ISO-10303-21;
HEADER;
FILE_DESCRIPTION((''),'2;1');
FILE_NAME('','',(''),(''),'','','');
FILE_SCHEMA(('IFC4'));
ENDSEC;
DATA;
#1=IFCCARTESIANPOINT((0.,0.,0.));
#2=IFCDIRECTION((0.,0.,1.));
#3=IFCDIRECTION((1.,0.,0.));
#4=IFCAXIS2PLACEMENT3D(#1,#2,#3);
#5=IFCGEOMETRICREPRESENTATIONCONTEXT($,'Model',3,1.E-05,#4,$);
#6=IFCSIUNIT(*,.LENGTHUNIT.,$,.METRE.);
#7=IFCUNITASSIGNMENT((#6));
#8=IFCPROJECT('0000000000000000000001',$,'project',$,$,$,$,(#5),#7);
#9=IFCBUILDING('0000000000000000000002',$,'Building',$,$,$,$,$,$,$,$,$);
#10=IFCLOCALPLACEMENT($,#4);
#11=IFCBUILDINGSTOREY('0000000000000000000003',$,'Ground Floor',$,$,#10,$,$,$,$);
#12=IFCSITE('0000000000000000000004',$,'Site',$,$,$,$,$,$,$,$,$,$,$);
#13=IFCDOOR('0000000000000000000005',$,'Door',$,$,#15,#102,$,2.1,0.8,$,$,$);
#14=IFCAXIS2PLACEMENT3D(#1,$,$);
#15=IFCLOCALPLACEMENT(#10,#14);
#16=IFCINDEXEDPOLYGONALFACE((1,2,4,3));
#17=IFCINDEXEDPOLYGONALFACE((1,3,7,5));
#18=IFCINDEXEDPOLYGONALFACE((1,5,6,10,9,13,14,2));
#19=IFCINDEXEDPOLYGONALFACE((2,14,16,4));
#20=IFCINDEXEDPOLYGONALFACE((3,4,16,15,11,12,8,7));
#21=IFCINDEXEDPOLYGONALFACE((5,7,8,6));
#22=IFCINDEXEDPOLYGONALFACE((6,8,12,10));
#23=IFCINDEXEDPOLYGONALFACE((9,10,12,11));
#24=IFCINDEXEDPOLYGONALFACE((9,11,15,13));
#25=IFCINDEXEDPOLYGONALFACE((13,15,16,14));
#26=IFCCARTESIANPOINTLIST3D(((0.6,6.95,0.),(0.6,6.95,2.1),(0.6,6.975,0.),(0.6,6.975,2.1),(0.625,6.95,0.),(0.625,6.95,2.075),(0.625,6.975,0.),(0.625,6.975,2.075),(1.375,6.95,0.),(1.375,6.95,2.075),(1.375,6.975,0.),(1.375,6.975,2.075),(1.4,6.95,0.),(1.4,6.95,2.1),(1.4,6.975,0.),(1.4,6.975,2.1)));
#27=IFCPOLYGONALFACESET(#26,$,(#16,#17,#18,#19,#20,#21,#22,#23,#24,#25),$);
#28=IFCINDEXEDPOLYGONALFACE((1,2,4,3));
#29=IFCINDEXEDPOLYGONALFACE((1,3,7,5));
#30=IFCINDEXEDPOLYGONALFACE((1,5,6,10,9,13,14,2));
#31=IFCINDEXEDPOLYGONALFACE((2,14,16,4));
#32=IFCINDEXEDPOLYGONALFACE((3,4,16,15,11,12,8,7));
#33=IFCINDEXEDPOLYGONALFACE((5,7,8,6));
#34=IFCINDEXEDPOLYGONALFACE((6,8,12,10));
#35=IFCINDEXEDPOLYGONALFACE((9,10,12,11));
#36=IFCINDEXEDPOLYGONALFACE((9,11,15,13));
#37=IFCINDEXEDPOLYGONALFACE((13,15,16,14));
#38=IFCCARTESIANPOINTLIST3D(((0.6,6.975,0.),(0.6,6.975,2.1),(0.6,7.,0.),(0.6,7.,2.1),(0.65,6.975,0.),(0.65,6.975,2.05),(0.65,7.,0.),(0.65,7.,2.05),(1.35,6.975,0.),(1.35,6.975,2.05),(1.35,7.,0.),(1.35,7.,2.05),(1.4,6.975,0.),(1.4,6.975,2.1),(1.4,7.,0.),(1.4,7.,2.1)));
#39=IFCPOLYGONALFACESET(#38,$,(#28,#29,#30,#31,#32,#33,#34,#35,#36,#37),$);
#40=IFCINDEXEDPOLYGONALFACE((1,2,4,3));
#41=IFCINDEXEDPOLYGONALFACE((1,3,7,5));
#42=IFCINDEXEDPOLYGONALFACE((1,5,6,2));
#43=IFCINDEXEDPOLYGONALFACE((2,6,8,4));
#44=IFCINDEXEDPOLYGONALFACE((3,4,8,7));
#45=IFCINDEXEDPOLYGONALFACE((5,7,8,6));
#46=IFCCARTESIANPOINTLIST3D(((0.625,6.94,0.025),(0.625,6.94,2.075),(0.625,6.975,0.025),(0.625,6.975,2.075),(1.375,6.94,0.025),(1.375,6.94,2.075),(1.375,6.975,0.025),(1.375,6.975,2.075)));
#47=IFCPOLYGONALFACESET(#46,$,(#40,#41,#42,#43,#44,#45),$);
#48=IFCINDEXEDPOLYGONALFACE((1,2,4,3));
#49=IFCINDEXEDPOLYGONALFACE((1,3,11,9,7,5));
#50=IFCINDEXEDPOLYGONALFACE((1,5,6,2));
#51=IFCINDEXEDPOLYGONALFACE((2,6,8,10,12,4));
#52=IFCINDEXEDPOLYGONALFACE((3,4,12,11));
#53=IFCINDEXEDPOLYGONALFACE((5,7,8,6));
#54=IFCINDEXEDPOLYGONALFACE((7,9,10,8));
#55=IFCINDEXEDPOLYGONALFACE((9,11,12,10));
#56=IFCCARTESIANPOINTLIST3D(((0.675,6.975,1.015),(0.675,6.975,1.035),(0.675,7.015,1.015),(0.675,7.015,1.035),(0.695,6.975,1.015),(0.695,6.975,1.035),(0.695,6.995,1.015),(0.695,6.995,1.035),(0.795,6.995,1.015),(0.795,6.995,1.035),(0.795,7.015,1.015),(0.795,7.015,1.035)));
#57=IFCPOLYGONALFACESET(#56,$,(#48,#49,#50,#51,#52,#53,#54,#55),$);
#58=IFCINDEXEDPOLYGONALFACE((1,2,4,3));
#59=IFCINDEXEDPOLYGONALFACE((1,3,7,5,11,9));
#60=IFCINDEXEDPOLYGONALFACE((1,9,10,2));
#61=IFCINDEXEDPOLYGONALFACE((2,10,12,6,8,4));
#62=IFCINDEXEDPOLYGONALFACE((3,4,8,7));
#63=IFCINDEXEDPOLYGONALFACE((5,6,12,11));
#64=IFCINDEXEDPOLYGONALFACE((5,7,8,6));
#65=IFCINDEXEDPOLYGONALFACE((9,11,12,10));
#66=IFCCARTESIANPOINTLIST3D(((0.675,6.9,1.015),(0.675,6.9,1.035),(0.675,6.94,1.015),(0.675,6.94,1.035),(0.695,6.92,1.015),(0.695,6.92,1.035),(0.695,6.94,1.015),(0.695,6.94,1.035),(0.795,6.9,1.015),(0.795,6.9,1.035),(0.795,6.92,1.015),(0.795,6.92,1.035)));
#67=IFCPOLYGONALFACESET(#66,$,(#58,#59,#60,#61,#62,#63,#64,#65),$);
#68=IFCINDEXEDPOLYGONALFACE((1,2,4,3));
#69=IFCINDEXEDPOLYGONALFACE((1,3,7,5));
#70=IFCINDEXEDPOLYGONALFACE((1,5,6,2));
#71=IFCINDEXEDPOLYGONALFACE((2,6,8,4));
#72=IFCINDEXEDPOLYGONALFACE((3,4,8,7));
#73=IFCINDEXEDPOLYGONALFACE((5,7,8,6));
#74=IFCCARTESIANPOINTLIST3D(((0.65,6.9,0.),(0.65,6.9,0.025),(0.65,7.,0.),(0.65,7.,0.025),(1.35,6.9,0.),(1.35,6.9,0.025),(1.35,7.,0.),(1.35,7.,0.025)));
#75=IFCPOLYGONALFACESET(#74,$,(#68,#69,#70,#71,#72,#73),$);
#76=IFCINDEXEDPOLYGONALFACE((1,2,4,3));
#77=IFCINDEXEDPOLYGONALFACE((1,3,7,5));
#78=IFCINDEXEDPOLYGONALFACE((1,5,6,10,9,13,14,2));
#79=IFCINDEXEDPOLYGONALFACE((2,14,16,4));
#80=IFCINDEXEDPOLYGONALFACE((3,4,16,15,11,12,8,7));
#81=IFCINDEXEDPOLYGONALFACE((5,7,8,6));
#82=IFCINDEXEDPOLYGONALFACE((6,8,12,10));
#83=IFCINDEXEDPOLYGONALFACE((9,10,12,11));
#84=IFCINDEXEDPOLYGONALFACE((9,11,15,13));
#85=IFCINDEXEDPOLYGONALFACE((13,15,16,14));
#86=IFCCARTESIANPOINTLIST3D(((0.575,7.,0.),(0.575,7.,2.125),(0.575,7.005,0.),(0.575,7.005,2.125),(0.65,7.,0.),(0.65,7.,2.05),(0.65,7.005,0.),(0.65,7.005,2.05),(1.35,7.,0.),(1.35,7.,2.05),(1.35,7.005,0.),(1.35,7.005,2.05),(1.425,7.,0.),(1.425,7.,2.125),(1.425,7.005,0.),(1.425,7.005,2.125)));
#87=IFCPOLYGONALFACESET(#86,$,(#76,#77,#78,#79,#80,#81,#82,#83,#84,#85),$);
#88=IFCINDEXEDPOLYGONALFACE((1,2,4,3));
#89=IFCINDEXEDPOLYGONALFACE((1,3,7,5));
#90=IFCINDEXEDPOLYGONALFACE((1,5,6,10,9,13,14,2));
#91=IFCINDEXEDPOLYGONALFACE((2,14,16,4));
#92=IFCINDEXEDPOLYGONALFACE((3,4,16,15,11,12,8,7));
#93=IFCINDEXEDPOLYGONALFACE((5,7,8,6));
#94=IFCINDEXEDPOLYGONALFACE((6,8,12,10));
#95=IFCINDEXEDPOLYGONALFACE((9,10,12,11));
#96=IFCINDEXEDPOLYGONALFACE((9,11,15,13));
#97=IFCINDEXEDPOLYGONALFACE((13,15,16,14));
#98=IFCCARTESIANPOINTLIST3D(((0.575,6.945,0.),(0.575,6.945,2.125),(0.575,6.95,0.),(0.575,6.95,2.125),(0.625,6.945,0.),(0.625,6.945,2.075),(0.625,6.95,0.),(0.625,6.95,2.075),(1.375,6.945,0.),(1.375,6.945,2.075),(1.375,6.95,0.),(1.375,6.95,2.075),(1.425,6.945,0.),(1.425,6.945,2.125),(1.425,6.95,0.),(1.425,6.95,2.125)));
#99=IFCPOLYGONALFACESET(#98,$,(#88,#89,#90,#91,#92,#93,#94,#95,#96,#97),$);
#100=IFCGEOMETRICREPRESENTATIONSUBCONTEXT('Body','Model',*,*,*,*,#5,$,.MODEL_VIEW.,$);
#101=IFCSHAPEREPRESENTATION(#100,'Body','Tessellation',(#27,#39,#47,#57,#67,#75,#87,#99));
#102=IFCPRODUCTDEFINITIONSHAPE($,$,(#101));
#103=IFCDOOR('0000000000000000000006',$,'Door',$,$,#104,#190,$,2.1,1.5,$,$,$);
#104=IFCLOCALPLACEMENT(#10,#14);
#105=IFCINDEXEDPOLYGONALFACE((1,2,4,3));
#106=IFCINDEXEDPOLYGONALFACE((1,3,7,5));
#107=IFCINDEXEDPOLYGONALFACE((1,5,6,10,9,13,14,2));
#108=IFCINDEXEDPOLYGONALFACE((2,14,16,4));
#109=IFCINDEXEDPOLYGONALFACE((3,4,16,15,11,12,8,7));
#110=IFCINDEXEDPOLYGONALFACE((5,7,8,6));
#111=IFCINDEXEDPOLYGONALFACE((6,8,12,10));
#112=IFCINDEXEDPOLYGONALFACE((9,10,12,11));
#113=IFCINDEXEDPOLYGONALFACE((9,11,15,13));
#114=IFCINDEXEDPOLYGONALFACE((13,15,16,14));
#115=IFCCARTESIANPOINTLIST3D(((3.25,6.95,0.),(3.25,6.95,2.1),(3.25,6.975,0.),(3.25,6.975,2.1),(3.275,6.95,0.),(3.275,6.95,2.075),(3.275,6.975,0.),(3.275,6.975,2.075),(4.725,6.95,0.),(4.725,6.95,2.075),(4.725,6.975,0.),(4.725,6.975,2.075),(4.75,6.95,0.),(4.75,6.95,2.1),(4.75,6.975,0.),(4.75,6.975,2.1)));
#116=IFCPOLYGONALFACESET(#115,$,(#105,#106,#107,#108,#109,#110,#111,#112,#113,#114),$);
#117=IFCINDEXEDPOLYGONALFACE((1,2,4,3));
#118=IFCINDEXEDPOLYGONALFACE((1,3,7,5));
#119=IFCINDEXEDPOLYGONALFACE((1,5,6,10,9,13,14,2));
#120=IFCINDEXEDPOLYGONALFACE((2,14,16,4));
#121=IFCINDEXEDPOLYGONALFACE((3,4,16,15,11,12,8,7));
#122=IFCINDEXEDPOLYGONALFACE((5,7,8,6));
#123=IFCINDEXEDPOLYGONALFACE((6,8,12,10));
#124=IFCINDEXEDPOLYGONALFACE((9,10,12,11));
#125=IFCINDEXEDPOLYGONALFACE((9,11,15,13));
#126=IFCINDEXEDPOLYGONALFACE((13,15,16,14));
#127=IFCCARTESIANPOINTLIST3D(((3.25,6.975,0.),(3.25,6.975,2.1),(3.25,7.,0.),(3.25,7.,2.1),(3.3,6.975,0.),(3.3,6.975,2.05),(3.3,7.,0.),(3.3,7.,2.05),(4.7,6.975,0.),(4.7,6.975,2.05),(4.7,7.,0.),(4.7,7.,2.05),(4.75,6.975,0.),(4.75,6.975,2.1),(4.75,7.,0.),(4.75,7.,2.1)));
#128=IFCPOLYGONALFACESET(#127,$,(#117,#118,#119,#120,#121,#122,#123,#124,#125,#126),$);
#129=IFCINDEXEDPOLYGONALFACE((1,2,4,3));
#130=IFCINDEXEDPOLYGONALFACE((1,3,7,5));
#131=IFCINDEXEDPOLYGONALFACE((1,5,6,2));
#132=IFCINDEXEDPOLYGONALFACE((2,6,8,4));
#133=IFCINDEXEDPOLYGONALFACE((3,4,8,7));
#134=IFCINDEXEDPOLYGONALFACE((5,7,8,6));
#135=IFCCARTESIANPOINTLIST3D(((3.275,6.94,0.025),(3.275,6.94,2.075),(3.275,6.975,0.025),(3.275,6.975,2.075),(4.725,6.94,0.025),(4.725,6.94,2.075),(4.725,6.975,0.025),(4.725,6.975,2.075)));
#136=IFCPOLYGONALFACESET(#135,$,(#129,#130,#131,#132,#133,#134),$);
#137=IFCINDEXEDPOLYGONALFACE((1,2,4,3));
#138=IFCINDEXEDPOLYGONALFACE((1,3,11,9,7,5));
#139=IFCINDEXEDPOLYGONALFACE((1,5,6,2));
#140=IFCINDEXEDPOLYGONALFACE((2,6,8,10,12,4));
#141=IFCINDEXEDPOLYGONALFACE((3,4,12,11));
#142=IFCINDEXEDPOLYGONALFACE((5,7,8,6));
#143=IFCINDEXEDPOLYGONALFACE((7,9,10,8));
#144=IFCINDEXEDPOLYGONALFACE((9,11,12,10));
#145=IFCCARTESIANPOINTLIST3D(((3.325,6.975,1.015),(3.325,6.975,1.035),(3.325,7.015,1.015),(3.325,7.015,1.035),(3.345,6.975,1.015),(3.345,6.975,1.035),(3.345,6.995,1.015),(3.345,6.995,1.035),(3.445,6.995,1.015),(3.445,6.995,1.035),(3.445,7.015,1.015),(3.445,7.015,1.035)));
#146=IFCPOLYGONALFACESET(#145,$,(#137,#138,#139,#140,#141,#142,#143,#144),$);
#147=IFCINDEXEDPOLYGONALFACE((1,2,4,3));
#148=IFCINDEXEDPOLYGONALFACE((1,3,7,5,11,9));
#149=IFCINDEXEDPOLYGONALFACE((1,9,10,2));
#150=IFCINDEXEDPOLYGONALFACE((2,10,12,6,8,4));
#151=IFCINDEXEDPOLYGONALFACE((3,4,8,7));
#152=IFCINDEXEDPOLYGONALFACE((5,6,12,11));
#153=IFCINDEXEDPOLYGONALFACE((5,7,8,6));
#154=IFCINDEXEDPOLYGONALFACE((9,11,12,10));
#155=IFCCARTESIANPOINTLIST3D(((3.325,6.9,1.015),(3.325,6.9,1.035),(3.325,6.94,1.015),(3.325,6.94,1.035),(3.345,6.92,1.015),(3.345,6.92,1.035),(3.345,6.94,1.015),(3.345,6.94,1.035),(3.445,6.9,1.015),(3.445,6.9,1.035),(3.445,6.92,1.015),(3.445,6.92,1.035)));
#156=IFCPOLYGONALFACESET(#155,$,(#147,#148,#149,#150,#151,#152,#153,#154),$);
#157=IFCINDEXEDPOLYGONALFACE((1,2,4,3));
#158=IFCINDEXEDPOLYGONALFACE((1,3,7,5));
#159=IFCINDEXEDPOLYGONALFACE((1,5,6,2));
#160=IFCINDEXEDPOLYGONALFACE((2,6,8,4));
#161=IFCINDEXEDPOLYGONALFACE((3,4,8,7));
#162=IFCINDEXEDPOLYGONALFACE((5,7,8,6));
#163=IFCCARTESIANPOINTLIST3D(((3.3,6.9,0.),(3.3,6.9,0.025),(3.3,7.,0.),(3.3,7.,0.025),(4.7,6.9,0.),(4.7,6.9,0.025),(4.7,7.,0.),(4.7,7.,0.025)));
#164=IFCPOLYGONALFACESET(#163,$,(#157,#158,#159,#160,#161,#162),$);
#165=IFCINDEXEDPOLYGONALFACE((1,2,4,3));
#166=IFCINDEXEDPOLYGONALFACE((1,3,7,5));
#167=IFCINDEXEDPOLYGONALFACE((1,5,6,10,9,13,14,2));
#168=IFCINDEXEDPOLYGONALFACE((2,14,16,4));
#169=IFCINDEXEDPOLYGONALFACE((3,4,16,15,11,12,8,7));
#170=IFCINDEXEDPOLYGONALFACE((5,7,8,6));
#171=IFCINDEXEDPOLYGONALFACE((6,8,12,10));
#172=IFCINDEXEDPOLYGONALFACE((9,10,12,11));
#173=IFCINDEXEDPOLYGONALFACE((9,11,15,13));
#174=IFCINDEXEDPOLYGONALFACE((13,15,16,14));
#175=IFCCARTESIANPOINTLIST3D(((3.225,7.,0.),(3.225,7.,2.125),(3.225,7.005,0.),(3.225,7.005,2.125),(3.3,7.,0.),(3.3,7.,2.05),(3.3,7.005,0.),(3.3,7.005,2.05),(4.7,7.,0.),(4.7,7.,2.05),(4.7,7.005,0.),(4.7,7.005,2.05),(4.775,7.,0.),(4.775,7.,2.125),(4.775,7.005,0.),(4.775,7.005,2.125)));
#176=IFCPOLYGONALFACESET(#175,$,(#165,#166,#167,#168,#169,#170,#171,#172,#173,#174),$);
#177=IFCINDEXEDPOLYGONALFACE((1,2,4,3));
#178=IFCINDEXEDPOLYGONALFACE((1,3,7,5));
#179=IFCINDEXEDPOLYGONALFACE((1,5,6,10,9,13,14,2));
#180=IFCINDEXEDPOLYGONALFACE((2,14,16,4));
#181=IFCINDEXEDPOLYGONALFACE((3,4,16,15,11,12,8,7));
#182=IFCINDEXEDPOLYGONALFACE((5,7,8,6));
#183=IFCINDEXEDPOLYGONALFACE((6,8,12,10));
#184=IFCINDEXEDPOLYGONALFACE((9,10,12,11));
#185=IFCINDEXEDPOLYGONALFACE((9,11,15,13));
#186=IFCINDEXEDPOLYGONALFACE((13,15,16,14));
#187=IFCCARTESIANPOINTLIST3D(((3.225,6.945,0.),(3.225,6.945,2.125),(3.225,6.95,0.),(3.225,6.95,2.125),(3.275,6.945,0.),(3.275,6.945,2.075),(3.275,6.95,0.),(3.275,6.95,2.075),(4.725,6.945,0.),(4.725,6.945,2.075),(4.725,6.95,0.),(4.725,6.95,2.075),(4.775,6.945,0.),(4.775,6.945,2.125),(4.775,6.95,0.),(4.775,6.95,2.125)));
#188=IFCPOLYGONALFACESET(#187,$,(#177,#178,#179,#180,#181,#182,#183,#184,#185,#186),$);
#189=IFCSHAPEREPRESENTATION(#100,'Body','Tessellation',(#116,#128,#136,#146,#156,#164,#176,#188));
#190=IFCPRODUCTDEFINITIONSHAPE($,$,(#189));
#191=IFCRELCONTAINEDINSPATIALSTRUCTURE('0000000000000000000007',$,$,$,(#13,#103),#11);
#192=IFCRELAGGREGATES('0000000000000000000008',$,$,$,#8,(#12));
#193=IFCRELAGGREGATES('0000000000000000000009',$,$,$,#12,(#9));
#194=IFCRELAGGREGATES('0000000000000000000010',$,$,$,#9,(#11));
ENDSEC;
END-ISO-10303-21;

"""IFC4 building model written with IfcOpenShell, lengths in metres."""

from ifc_helpers import new_model, si_unit, frame, origin_with_axes, place, context, subcontext, project, spatial, line, indexed_curve, outline, extrude, element, save


model = new_model("IFC4")

# Units and contexts
model_context = context("Model", 3, precision=1e-05, world=origin_with_axes())
body_context = subcontext(model_context, "Body", "Model", "MODEL_VIEW")
ifc_project = project(units=[si_unit("LENGTHUNIT", "METRE")], contexts=[model_context])

# Site, building, storey
site = spatial("IfcSite", under=ifc_project, Name="Site")
building = spatial("IfcBuilding", under=site, Name="Building")
storey_placement = place(None, origin_with_axes())
storey = spatial("IfcBuildingStorey", under=building, at=storey_placement, Name="Ground Floor")

# Doors
door_1_placement = place(storey_placement, frame((1.4, 7.0, 0.0), z_axis=(0.0, 0.0, 1.0), x_axis=(-1.0, 0.0, 0.0)))
element("IfcDoor", 1, at=door_1_placement, inside=storey, Name="Door", OverallHeight=2.1, OverallWidth=0.8, context=body_context, shape_type="SweptSolid", body=[
    extrude(outline(indexed_curve([(0.0, 0.0), (0.0, 2.1), (0.8, 2.1), (0.8, 0.0), (0.775, 0.0), (0.775, 2.075), (0.025, 2.075), (0.025, 0.0)], segments=[line(1, 2, 3, 4, 5, 6, 7, 8, 1)])), frame((0.0, 0.025, 0.0), z_axis=(0.0, -1.0, 0.0), x_axis=(1.0, 0.0, 0.0)), (0.0, 0.0, -1.0), 0.025),
    extrude(outline(indexed_curve([(0.0, 0.0), (0.0, 2.1), (0.8, 2.1), (0.8, 0.0), (0.75, 0.0), (0.75, 2.05), (0.05, 2.05), (0.05, 0.0)], segments=[line(1, 2, 3, 4, 5, 6, 7, 8, 1)])), frame((0.0, 0.0, 0.0), z_axis=(0.0, -1.0, 0.0), x_axis=(1.0, 0.0, 0.0)), (0.0, 0.0, -1.0), 0.025),
    extrude(outline(indexed_curve([(0.0, 0.0), (0.75, 0.0), (0.75, 0.035), (0.0, 0.035)], segments=[line(1, 2, 3, 4, 1)])), frame((0.025, 0.025, 0.025), z_axis=(0.0, 0.0, 1.0), x_axis=(1.0, 0.0, 0.0)), (0.0, 0.0, 1.0), 2.05),
    extrude(outline(indexed_curve([(0.0, 0.0), (0.0, -0.04), (-0.12, -0.04), (-0.12, -0.02), (-0.02, -0.02), (-0.02, 0.0)], segments=[line(1, 2, 3, 4, 5, 6, 1)])), frame((0.725, 0.025, 1.015), z_axis=(0.0, 0.0, 1.0), x_axis=(1.0, 0.0, 0.0)), (0.0, 0.0, 1.0), 0.02),
    extrude(outline(indexed_curve([(0.0, 0.0), (0.0, 0.04), (-0.12, 0.04), (-0.12, 0.02), (-0.02, 0.02), (-0.02, 0.0)], segments=[line(1, 2, 3, 4, 5, 6, 1)])), frame((0.725, 0.06, 1.015), z_axis=(0.0, 0.0, 1.0), x_axis=(1.0, 0.0, 0.0)), (0.0, 0.0, 1.0), 0.02),
    extrude(outline(indexed_curve([(0.0, 0.0), (0.7, 0.0), (0.7, 0.1), (0.0, 0.1)], segments=[line(1, 2, 3, 4, 1)])), frame((0.05, 0.0, 0.0), z_axis=(0.0, 0.0, 1.0), x_axis=(1.0, 0.0, 0.0)), (0.0, 0.0, 1.0), 0.025),
    extrude(outline(indexed_curve([(0.0, 0.0), (0.0, 2.125), (0.85, 2.125), (0.85, 0.0), (0.775, 0.0), (0.775, 2.05), (0.075, 2.05), (0.075, 0.0)], segments=[line(1, 2, 3, 4, 5, 6, 7, 8, 1)])), frame((-0.025, -0.005, 0.0), z_axis=(0.0, -1.0, 0.0), x_axis=(1.0, 0.0, 0.0)), (0.0, 0.0, -1.0), 0.005),
    extrude(outline(indexed_curve([(0.0, 0.0), (0.0, 2.125), (0.85, 2.125), (0.85, 0.0), (0.8, 0.0), (0.8, 2.075), (0.05, 2.075), (0.05, 0.0)], segments=[line(1, 2, 3, 4, 5, 6, 7, 8, 1)])), frame((-0.025, 0.05, 0.0), z_axis=(0.0, -1.0, 0.0), x_axis=(1.0, 0.0, 0.0)), (0.0, 0.0, -1.0), 0.005),
])
door_2_placement = place(storey_placement, frame((4.75, 7.0, 0.0), z_axis=(0.0, 0.0, 1.0), x_axis=(-1.0, 0.0, 0.0)))
element("IfcDoor", 2, at=door_2_placement, inside=storey, Name="Door", OverallHeight=2.1, OverallWidth=1.5, context=body_context, shape_type="SweptSolid", body=[
    extrude(outline(indexed_curve([(0.0, 0.0), (0.0, 2.1), (1.5, 2.1), (1.5, 0.0), (1.475, 0.0), (1.475, 2.075), (0.025, 2.075), (0.025, 0.0)], segments=[line(1, 2, 3, 4, 5, 6, 7, 8, 1)])), frame((0.0, 0.025, 0.0), z_axis=(0.0, -1.0, 0.0), x_axis=(1.0, 0.0, 0.0)), (0.0, 0.0, -1.0), 0.025),
    extrude(outline(indexed_curve([(0.0, 0.0), (0.0, 2.1), (1.5, 2.1), (1.5, 0.0), (1.45, 0.0), (1.45, 2.05), (0.05, 2.05), (0.05, 0.0)], segments=[line(1, 2, 3, 4, 5, 6, 7, 8, 1)])), frame((0.0, 0.0, 0.0), z_axis=(0.0, -1.0, 0.0), x_axis=(1.0, 0.0, 0.0)), (0.0, 0.0, -1.0), 0.025),
    extrude(outline(indexed_curve([(0.0, 0.0), (1.45, 0.0), (1.45, 0.035), (0.0, 0.035)], segments=[line(1, 2, 3, 4, 1)])), frame((0.025, 0.025, 0.025), z_axis=(0.0, 0.0, 1.0), x_axis=(1.0, 0.0, 0.0)), (0.0, 0.0, 1.0), 2.05),
    extrude(outline(indexed_curve([(0.0, 0.0), (0.0, -0.04), (-0.12, -0.04), (-0.12, -0.02), (-0.02, -0.02), (-0.02, 0.0)], segments=[line(1, 2, 3, 4, 5, 6, 1)])), frame((1.425, 0.025, 1.015), z_axis=(0.0, 0.0, 1.0), x_axis=(1.0, 0.0, 0.0)), (0.0, 0.0, 1.0), 0.02),
    extrude(outline(indexed_curve([(0.0, 0.0), (0.0, 0.04), (-0.12, 0.04), (-0.12, 0.02), (-0.02, 0.02), (-0.02, 0.0)], segments=[line(1, 2, 3, 4, 5, 6, 1)])), frame((1.425, 0.06, 1.015), z_axis=(0.0, 0.0, 1.0), x_axis=(1.0, 0.0, 0.0)), (0.0, 0.0, 1.0), 0.02),
    extrude(outline(indexed_curve([(0.0, 0.0), (1.4, 0.0), (1.4, 0.1), (0.0, 0.1)], segments=[line(1, 2, 3, 4, 1)])), frame((0.05, 0.0, 0.0), z_axis=(0.0, 0.0, 1.0), x_axis=(1.0, 0.0, 0.0)), (0.0, 0.0, 1.0), 0.025),
    extrude(outline(indexed_curve([(0.0, 0.0), (0.0, 2.125), (1.55, 2.125), (1.55, 0.0), (1.475, 0.0), (1.475, 2.05), (0.075, 2.05), (0.075, 0.0)], segments=[line(1, 2, 3, 4, 5, 6, 7, 8, 1)])), frame((-0.025, -0.005, 0.0), z_axis=(0.0, -1.0, 0.0), x_axis=(1.0, 0.0, 0.0)), (0.0, 0.0, -1.0), 0.005),
    extrude(outline(indexed_curve([(0.0, 0.0), (0.0, 2.125), (1.55, 2.125), (1.55, 0.0), (1.5, 0.0), (1.5, 2.075), (0.05, 2.075), (0.05, 0.0)], segments=[line(1, 2, 3, 4, 5, 6, 7, 8, 1)])), frame((-0.025, 0.05, 0.0), z_axis=(0.0, -1.0, 0.0), x_axis=(1.0, 0.0, 0.0)), (0.0, 0.0, -1.0), 0.005),
])

save(model, "model.ifc")
